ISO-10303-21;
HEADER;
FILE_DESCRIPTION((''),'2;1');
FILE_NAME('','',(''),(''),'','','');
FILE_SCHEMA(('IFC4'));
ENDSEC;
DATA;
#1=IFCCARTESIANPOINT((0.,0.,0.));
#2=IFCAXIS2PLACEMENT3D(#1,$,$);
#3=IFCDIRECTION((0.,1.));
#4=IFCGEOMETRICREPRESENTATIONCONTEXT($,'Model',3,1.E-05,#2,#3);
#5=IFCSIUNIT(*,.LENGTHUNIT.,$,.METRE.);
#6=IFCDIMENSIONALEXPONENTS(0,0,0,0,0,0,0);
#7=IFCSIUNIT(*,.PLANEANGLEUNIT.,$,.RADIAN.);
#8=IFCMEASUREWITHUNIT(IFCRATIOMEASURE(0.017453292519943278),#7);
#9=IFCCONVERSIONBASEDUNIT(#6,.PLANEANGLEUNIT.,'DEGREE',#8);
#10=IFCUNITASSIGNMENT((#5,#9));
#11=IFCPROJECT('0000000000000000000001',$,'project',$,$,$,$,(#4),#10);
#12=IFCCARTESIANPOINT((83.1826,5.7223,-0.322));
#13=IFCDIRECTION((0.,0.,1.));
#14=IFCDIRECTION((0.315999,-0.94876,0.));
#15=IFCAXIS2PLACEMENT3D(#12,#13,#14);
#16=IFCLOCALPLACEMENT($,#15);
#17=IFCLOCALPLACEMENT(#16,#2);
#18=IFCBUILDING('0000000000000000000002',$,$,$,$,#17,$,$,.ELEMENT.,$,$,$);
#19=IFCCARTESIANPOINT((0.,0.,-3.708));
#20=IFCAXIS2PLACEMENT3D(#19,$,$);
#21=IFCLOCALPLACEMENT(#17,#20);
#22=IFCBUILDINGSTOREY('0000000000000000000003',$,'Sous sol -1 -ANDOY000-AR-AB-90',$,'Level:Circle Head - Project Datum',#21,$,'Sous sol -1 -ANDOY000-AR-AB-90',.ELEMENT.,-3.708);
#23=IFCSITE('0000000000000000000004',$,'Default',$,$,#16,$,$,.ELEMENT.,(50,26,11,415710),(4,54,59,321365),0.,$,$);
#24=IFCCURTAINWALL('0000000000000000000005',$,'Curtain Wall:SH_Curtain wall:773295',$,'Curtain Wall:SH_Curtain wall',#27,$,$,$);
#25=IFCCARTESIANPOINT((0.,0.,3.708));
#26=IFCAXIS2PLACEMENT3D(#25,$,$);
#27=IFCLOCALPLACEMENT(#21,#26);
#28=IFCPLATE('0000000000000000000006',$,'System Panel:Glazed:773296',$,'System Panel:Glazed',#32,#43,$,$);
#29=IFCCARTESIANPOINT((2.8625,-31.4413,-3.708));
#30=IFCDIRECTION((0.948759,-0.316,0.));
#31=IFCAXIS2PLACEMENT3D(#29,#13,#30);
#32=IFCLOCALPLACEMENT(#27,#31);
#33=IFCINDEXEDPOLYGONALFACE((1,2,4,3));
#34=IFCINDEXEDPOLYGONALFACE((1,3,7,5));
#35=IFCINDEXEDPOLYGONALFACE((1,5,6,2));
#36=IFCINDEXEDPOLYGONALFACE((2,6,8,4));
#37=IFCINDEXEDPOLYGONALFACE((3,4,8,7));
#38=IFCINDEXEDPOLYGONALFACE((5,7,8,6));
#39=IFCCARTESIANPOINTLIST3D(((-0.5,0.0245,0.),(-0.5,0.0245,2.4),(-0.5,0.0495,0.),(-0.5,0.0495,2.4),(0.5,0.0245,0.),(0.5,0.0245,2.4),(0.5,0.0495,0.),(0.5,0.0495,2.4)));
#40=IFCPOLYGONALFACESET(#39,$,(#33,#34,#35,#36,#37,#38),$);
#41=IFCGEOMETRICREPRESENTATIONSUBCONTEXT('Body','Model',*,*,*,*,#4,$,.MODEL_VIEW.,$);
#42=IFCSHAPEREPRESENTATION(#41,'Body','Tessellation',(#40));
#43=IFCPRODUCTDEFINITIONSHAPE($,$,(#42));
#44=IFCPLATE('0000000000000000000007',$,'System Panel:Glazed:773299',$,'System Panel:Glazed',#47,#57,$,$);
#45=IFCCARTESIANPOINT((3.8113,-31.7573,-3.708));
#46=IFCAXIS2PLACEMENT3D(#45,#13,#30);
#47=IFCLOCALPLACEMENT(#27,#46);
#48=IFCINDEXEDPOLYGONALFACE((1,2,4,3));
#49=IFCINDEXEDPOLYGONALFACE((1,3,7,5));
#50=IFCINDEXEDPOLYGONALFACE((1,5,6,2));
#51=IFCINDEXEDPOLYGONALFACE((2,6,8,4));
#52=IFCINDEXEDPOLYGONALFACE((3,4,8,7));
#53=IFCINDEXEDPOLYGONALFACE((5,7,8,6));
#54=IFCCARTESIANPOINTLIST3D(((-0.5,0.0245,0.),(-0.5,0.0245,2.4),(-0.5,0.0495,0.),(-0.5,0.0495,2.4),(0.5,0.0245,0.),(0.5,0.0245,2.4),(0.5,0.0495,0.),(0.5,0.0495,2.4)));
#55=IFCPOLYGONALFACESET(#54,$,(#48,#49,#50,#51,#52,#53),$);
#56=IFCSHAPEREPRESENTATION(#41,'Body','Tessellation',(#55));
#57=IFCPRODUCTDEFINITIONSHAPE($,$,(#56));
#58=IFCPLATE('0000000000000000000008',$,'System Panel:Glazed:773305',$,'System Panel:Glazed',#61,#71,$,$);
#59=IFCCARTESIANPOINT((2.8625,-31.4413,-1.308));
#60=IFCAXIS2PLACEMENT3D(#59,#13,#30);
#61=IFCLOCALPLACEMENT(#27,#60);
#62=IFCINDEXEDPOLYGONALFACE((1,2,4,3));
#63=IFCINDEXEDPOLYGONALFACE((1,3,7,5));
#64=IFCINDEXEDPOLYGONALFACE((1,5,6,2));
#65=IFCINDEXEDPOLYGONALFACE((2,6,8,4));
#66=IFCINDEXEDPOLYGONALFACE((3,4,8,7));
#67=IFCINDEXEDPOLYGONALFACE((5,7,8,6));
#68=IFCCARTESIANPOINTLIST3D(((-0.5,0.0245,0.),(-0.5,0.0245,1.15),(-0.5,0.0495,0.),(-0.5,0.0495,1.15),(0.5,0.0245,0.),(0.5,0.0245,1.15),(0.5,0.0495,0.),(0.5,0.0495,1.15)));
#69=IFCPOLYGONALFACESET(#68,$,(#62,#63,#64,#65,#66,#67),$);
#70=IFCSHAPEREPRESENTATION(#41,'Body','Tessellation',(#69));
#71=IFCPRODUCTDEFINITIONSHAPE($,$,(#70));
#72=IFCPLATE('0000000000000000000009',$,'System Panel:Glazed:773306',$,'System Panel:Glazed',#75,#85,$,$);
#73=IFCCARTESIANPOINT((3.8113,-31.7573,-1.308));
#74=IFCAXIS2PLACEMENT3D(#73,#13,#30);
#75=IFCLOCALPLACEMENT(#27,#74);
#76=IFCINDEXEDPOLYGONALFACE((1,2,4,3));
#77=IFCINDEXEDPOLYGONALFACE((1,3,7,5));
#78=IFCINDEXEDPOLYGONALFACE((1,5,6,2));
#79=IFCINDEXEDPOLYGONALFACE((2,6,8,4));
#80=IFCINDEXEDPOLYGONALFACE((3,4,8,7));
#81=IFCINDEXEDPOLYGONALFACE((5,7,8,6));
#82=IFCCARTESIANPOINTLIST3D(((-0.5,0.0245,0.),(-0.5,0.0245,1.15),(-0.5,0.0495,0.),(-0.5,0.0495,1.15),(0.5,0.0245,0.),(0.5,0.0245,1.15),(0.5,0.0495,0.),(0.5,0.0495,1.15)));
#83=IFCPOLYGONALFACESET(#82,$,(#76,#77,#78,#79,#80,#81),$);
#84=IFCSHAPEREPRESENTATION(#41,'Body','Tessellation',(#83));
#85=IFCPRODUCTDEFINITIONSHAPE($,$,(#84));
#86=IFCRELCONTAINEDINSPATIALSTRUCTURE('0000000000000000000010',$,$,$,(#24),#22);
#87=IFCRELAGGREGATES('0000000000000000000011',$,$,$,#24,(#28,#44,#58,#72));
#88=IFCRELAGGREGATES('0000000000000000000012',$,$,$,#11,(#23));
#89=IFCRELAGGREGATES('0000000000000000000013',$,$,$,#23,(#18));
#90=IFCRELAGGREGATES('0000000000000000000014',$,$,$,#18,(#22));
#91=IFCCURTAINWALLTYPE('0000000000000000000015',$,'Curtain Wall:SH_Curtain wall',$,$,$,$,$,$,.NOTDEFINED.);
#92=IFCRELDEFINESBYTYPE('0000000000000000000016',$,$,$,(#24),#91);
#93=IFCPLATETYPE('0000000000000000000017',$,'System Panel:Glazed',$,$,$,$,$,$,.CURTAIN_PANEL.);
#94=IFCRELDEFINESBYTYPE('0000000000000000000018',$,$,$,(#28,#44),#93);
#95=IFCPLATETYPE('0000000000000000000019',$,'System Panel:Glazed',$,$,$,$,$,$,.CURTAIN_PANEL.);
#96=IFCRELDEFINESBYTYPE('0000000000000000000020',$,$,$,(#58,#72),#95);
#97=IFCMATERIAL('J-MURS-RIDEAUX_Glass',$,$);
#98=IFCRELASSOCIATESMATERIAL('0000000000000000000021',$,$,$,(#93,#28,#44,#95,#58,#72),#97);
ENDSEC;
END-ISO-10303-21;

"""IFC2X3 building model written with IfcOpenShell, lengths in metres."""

from ifc_helpers import new_model, entity, si_unit, converted_unit, direction, frame, frame_2d, origin, origin_2d_with_axis, place, context, subcontext, project, spatial, rectangle, extrude, source, transform, mapped, material, type_object, type_shapes, element, aggregate, save


model = new_model("IFC2X3")

# Units and contexts
model_context = context("Model", 3, precision=1e-05, world=origin(), true_north=direction((0.0, 1.0)))
body_context = subcontext(model_context, "Body", "Model", "MODEL_VIEW")
ifc_project = project(units=[si_unit("LENGTHUNIT", "METRE"), converted_unit("PLANEANGLEUNIT", "DEGREE", entity("IfcRatioMeasure", 0.017453292519943278), si_unit("PLANEANGLEUNIT", "RADIAN"), dimensions=[0, 0, 0, 0, 0, 0, 0])], contexts=[model_context])

# Site, building, storey
site_placement = place(None, frame((83.1826, 5.7223, -0.322), z_axis=(0.0, 0.0, 1.0), x_axis=(0.315999, -0.94876, 0.0)))
site = spatial("IfcSite", under=ifc_project, at=site_placement, Name="Default", CompositionType="ELEMENT", RefLatitude=(50, 26, 11, 415710), RefLongitude=(4, 54, 59, 321365), RefElevation=0.0)
building_placement = place(site_placement, origin())
building = spatial("IfcBuilding", under=site, at=building_placement, CompositionType="ELEMENT")
storey_placement = place(building_placement, frame((0.0, 0.0, -3.708)))
storey = spatial("IfcBuildingStorey", under=building, at=storey_placement, Name="Sous sol -1 -ANDOY000-AR-AB-90", ObjectType="Level:Circle Head - Project Datum", LongName="Sous sol -1 -ANDOY000-AR-AB-90", CompositionType="ELEMENT", Elevation=-3.708)

# Curtain wall
curtain_wall_type = type_object("IfcCurtainWallType", Name="Curtain Wall:SH_Curtain wall", PredefinedType="NOTDEFINED")
curtain_wall_1_placement = place(storey_placement, frame((0.0, 0.0, 3.708)))
curtain_wall_1 = element("IfcCurtainWall", 1, at=curtain_wall_1_placement, inside=storey, type_object=curtain_wall_type, Name="Curtain Wall:SH_Curtain wall:773295", ObjectType="Curtain Wall:SH_Curtain wall")

# Plates
ifc_material_1 = material(Name="J-MURS-RIDEAUX_Glass")
plate_type_1 = type_object("IfcPlateType", Name="System Panel:Glazed", PredefinedType="CURTAIN_PANEL", material=ifc_material_1)
shared_shape_1 = source(origin(), body_context, "Body", "SweptSolid", [
    extrude(rectangle(XDim=0.025, YDim=1.0, at=frame_2d((0.0, 0.0), x_axis=(1.0, 0.0))), frame((0.0, 0.037, 0.0), z_axis=(0.0, 0.0, 1.0), x_axis=(0.0, 1.0, 0.0)), (0.0, 0.0, 1.0), 2.4),
])
type_shapes(plate_type_1, [shared_shape_1])
plate_1_placement = place(curtain_wall_1_placement, frame((2.8625, -31.4413, -3.708), z_axis=(0.0, 0.0, 1.0), x_axis=(0.948759, -0.316, 0.0)))
plate_1 = element("IfcPlate", 2, at=plate_1_placement, type_object=plate_type_1, material=ifc_material_1, Name="System Panel:Glazed:773296", ObjectType="System Panel:Glazed", context=body_context, shape_type="MappedRepresentation", body=[
    mapped(shared_shape_1, transform((0.0, 0.0, 0.0), scale=1.0)),
])
plate_2_placement = place(curtain_wall_1_placement, frame((3.8113, -31.7573, -3.708), z_axis=(0.0, 0.0, 1.0), x_axis=(0.948759, -0.316, 0.0)))
plate_2 = element("IfcPlate", 3, at=plate_2_placement, type_object=plate_type_1, material=ifc_material_1, Name="System Panel:Glazed:773299", ObjectType="System Panel:Glazed", context=body_context, shape_type="MappedRepresentation", body=[
    mapped(shared_shape_1, transform((0.0, 0.0, 0.0), scale=1.0)),
])
plate_type_2 = type_object("IfcPlateType", Name="System Panel:Glazed", PredefinedType="CURTAIN_PANEL", material=ifc_material_1)
shared_shape_2 = source(origin(), body_context, "Body", "SweptSolid", [
    extrude(rectangle(XDim=0.025, YDim=1.0, at=origin_2d_with_axis()), frame((0.0, 0.037, 0.0), z_axis=(0.0, 0.0, 1.0), x_axis=(0.0, 1.0, 0.0)), (0.0, 0.0, 1.0), 1.15),
])
type_shapes(plate_type_2, [shared_shape_2])
plate_3_placement = place(curtain_wall_1_placement, frame((2.8625, -31.4413, -1.308), z_axis=(0.0, 0.0, 1.0), x_axis=(0.948759, -0.316, 0.0)))
plate_3 = element("IfcPlate", 4, at=plate_3_placement, type_object=plate_type_2, material=ifc_material_1, Name="System Panel:Glazed:773305", ObjectType="System Panel:Glazed", context=body_context, shape_type="MappedRepresentation", body=[
    mapped(shared_shape_2, transform((0.0, 0.0, 0.0), scale=1.0)),
])
plate_4_placement = place(curtain_wall_1_placement, frame((3.8113, -31.7573, -1.308), z_axis=(0.0, 0.0, 1.0), x_axis=(0.948759, -0.316, 0.0)))
plate_4 = element("IfcPlate", 5, at=plate_4_placement, type_object=plate_type_2, material=ifc_material_1, Name="System Panel:Glazed:773306", ObjectType="System Panel:Glazed", context=body_context, shape_type="MappedRepresentation", body=[
    mapped(shared_shape_2, transform((0.0, 0.0, 0.0), scale=1.0)),
])
aggregate(curtain_wall_1, [plate_1, plate_2, plate_3, plate_4])

save(model, "model.ifc")
